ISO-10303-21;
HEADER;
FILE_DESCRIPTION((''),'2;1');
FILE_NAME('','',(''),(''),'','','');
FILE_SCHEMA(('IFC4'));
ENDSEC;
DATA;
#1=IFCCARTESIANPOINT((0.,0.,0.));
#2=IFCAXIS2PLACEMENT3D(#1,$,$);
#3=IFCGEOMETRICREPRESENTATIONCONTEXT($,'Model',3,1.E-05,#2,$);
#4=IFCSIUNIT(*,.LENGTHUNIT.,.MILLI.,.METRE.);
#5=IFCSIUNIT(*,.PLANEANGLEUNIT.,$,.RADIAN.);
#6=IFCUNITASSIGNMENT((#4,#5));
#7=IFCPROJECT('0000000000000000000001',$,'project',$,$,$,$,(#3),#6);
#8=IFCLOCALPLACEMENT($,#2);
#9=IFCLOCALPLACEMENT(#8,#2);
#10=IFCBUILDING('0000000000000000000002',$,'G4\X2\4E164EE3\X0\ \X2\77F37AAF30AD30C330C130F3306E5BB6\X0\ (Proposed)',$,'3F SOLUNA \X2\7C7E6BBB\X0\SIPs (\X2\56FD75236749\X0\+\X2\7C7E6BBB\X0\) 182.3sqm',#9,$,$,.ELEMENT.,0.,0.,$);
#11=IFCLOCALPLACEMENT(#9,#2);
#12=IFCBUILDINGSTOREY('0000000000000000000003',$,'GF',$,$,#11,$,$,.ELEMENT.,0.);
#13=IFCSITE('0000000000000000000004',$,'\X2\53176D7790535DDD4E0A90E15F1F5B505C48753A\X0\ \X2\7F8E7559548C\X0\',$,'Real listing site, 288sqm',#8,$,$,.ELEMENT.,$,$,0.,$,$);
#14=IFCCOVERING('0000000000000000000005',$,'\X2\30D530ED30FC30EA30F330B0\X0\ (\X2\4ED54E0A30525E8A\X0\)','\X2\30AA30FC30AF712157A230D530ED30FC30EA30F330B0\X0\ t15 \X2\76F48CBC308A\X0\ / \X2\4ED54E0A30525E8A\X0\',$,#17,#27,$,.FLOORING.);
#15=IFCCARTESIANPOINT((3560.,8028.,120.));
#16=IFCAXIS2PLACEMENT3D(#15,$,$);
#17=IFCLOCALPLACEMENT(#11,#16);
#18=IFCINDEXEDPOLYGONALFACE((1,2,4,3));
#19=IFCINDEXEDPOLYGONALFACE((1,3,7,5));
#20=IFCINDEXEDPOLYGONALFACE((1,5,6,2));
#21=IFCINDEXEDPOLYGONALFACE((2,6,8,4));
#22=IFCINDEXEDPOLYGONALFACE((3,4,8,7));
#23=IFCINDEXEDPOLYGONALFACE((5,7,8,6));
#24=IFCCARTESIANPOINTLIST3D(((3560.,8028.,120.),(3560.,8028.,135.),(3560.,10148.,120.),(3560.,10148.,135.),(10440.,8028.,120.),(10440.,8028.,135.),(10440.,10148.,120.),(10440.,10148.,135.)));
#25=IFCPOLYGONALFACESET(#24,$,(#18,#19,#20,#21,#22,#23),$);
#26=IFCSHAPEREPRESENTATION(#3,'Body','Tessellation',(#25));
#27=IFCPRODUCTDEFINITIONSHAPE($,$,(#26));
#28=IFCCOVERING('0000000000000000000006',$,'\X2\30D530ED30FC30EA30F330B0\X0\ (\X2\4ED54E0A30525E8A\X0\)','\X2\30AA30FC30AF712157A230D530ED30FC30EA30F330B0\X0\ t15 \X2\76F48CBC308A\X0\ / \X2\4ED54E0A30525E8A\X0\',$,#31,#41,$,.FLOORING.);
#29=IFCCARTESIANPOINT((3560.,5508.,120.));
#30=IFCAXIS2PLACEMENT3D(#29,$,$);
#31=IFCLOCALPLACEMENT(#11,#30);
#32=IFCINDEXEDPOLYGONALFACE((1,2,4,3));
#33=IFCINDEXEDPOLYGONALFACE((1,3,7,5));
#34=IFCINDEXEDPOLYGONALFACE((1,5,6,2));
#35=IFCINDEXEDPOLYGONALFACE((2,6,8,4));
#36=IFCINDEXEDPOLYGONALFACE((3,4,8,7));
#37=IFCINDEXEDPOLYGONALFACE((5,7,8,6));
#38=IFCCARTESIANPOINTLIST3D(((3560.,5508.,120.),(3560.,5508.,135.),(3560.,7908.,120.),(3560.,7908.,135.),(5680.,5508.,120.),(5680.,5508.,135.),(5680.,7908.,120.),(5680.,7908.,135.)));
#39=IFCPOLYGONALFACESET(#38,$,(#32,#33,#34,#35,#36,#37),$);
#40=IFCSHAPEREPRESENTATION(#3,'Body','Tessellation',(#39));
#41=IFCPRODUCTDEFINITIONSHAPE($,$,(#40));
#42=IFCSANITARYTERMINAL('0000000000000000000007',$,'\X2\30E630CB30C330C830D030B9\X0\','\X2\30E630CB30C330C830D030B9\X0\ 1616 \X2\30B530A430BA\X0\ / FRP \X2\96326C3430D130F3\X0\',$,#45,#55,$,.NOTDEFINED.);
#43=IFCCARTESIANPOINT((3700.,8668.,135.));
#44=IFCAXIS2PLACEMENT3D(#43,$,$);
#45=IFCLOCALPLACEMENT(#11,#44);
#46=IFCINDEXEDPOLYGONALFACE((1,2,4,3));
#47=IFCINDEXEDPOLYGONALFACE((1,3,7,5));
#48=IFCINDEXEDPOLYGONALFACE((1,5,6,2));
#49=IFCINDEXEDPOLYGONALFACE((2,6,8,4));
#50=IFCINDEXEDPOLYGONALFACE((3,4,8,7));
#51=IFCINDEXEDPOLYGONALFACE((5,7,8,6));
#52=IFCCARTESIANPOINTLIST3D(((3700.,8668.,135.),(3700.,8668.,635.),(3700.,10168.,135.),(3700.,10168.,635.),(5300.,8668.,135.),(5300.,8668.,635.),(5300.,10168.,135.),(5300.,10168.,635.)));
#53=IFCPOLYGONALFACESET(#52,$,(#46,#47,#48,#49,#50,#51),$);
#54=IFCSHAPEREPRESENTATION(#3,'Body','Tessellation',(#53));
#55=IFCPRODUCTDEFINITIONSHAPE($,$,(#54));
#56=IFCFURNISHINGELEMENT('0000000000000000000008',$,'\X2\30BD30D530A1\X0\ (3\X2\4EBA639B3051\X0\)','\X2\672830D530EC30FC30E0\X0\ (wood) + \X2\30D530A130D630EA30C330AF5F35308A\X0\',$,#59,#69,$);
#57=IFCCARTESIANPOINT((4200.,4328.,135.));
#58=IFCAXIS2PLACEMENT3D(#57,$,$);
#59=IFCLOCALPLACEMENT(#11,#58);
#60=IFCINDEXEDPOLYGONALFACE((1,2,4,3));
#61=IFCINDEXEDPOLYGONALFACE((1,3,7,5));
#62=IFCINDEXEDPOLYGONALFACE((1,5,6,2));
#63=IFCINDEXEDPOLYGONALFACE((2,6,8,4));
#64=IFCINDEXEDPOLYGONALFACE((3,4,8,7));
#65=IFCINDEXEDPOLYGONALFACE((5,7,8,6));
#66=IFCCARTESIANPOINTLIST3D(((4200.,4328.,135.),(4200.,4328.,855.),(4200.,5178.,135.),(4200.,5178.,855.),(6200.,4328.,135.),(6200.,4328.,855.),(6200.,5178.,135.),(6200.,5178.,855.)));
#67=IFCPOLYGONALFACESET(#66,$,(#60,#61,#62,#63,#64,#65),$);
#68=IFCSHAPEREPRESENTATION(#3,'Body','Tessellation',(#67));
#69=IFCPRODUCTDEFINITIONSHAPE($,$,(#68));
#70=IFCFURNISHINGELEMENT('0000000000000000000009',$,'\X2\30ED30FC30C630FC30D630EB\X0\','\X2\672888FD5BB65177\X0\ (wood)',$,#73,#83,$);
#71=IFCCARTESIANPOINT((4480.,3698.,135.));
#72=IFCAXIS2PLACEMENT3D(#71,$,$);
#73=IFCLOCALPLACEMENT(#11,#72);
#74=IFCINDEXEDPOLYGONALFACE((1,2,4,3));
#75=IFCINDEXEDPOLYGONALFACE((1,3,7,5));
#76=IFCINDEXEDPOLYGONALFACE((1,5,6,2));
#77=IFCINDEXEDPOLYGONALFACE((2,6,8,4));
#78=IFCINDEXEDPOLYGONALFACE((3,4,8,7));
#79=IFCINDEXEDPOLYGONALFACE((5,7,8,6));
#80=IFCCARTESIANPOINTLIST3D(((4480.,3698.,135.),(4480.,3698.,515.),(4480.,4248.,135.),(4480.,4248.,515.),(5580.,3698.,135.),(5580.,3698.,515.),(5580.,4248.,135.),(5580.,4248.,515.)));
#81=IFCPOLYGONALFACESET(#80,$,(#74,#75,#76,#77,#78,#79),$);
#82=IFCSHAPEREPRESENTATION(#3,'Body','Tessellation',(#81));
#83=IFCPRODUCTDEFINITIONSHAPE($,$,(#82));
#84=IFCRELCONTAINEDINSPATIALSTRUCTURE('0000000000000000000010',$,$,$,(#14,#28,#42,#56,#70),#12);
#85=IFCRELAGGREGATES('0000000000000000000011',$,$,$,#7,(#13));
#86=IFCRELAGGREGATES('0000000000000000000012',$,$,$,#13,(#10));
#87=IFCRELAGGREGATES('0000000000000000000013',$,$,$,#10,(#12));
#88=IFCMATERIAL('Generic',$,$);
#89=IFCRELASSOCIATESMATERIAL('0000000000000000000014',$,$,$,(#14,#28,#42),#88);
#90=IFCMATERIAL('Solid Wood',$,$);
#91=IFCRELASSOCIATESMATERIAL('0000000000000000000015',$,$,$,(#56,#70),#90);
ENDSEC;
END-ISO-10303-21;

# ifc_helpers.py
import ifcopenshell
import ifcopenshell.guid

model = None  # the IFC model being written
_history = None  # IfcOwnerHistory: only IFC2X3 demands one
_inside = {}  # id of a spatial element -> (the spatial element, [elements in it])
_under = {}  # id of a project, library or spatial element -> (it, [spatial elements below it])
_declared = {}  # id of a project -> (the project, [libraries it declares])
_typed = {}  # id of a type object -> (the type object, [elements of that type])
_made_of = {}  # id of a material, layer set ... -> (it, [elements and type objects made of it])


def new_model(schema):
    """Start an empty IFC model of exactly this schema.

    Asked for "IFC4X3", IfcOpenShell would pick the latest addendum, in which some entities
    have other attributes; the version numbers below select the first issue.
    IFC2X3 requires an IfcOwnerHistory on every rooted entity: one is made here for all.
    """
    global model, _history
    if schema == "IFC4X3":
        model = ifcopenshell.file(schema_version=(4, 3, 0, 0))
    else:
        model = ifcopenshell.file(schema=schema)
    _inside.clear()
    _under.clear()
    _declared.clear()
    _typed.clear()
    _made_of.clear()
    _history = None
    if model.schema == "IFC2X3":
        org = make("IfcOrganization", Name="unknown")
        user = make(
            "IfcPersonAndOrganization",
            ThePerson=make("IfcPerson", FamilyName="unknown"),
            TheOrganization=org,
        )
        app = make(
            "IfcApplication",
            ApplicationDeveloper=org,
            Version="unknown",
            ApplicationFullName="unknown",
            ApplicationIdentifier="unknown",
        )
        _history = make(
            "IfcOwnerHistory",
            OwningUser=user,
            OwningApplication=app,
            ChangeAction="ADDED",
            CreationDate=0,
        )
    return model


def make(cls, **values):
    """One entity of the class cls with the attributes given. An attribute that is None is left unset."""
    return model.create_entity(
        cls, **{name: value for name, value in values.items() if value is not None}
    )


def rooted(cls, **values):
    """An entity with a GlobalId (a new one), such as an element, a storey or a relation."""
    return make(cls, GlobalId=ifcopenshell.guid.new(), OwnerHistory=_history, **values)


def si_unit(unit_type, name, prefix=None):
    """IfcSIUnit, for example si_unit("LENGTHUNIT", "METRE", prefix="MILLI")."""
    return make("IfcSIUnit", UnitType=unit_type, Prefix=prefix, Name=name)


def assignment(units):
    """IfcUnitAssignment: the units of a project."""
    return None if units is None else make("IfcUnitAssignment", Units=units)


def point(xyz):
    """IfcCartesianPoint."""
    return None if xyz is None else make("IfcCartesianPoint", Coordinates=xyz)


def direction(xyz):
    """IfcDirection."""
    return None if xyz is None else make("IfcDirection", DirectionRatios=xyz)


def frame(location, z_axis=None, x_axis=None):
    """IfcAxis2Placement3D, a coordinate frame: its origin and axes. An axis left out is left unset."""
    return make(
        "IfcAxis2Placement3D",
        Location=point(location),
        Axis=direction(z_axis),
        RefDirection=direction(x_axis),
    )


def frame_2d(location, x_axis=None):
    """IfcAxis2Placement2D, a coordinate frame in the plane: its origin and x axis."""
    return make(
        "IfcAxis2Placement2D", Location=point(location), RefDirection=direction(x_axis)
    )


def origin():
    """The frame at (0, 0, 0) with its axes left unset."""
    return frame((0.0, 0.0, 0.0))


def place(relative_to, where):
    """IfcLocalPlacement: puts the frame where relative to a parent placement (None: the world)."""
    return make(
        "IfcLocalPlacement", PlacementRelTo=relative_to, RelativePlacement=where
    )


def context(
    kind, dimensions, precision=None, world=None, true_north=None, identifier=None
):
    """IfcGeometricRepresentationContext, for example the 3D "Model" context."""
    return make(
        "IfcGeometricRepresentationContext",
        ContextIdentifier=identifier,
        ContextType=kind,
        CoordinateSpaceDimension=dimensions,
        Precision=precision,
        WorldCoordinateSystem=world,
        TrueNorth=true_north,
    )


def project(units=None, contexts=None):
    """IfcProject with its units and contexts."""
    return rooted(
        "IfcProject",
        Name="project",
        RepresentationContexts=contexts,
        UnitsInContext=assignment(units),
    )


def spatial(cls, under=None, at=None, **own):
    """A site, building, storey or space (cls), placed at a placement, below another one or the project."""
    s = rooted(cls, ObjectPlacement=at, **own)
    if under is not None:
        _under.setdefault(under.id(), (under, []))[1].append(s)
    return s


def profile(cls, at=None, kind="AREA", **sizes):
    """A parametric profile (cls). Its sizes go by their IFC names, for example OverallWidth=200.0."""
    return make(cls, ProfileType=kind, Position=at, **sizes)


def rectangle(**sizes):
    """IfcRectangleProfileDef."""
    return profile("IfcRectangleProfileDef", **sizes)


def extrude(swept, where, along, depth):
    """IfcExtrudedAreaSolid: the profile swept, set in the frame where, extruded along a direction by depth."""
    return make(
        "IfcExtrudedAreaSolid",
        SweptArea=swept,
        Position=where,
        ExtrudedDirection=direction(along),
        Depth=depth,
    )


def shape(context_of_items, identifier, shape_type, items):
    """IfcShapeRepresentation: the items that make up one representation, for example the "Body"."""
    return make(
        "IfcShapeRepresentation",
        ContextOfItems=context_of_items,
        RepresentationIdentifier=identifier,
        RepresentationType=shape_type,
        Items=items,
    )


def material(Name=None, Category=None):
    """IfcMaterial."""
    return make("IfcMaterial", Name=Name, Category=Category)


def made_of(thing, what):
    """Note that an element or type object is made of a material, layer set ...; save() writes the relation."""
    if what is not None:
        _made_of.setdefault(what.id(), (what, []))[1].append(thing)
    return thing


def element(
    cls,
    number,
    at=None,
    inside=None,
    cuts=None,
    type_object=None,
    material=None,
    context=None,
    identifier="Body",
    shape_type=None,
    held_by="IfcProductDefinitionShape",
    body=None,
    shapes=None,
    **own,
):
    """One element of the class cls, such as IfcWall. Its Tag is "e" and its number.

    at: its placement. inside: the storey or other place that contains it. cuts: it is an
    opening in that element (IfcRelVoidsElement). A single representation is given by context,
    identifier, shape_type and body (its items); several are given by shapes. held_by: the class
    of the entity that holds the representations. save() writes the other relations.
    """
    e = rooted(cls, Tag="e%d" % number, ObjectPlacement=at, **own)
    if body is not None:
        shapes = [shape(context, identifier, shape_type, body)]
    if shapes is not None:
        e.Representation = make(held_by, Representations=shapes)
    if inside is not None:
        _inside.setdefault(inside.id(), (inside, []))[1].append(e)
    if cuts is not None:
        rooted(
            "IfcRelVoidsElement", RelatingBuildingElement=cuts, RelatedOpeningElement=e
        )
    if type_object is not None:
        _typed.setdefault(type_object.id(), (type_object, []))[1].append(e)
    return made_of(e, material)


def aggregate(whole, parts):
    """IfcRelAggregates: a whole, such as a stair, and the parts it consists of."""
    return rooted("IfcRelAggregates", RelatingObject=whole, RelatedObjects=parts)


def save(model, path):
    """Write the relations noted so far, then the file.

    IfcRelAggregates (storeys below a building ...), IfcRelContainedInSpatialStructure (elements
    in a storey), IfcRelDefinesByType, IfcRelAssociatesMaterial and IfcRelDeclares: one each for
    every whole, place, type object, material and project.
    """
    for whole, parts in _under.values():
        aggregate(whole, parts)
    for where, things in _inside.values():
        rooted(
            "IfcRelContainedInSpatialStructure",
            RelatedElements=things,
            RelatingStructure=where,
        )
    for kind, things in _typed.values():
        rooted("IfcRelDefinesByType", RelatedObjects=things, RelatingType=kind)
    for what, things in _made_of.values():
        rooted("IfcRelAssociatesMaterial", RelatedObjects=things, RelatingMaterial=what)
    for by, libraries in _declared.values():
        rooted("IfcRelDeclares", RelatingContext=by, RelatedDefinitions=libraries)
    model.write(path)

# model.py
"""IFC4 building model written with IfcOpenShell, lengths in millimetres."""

from ifc_helpers import new_model, si_unit, frame, frame_2d, origin, place, context, project, spatial, rectangle, extrude, material, element, save


model = new_model("IFC4")

# Units and contexts
model_context = context("Model", 3, precision=1e-05, world=origin())
ifc_project = project(units=[si_unit("LENGTHUNIT", "METRE", prefix="MILLI"), si_unit("PLANEANGLEUNIT", "RADIAN")], contexts=[model_context])

# Site, building, storey
site_placement = place(None, origin())
site = spatial("IfcSite", under=ifc_project, at=site_placement, Name="北海道川上郡弟子屈町 美留和", ObjectType="Real listing site, 288sqm", CompositionType="ELEMENT", RefElevation=0.0)
building_placement = place(site_placement, origin())
building = spatial("IfcBuilding", under=site, at=building_placement, Name="G4世代 石窯キッチンの家 (Proposed)", ObjectType="3F SOLUNA 籾殻SIPs (国産杉+籾殻) 182.3sqm", CompositionType="ELEMENT", ElevationOfRefHeight=0.0, ElevationOfTerrain=0.0)
storey_placement = place(building_placement, origin())
storey = spatial("IfcBuildingStorey", under=building, at=storey_placement, Name="GF", CompositionType="ELEMENT", Elevation=0.0)

# Shared definitions
ifc_material_1 = material(Name="Solid Wood")

# Coverings
ifc_material_2 = material(Name="Generic")
covering_1_placement = place(storey_placement, frame((3560.0, 8028.0, 120.0)))
element("IfcCovering", 1, at=covering_1_placement, inside=storey, material=ifc_material_2, Name="フローリング (仕上げ床)", Description="オーク無垢フローリング t15 直貼り / 仕上げ床", PredefinedType="FLOORING", context=model_context, shape_type="SweptSolid", body=[
    extrude(rectangle(XDim=6880.0, YDim=2120.0, at=frame_2d((3440.0, 1060.0))), frame((3560.0, 8028.0, 120.0)), (0.0, 0.0, 1.0), 15.0),
])
covering_2_placement = place(storey_placement, frame((3560.0, 5508.0, 120.0)))
element("IfcCovering", 2, at=covering_2_placement, inside=storey, material=ifc_material_2, Name="フローリング (仕上げ床)", Description="オーク無垢フローリング t15 直貼り / 仕上げ床", PredefinedType="FLOORING", context=model_context, shape_type="SweptSolid", body=[
    extrude(rectangle(XDim=2120.0, YDim=2400.0, at=frame_2d((1060.0, 1200.0))), frame((3560.0, 5508.0, 120.0)), (0.0, 0.0, 1.0), 15.0),
])

# Sanitary terminal
sanitary_terminal_placement = place(storey_placement, frame((3700.0, 8668.0, 135.0)))
element("IfcSanitaryTerminal", 3, at=sanitary_terminal_placement, inside=storey, material=ifc_material_2, Name="ユニットバス", Description="ユニットバス 1616 サイズ / FRP 防水パン", PredefinedType="NOTDEFINED", context=model_context, shape_type="SweptSolid", body=[
    extrude(rectangle(XDim=1600.0, YDim=1500.0, at=frame_2d((800.0, 750.0))), frame((3700.0, 8668.0, 135.0)), (0.0, 0.0, 1.0), 500.0),
])

# Furnishing elements
furnishing_1_placement = place(storey_placement, frame((4200.0, 4328.0, 135.0)))
element("IfcFurnishingElement", 4, at=furnishing_1_placement, inside=storey, material=ifc_material_1, Name="ソファ (3人掛け)", Description="木フレーム (wood) + ファブリック張り", context=model_context, shape_type="SweptSolid", body=[
    extrude(rectangle(XDim=2000.0, YDim=850.0, at=frame_2d((1000.0, 425.0))), frame((4200.0, 4328.0, 135.0)), (0.0, 0.0, 1.0), 720.0),
])
furnishing_2_placement = place(storey_placement, frame((4480.0, 3698.0, 135.0)))
element("IfcFurnishingElement", 5, at=furnishing_2_placement, inside=storey, material=ifc_material_1, Name="ローテーブル", Description="木製家具 (wood)", context=model_context, shape_type="SweptSolid", body=[
    extrude(rectangle(XDim=1100.0, YDim=550.0, at=frame_2d((550.0, 275.0))), frame((4480.0, 3698.0, 135.0)), (0.0, 0.0, 1.0), 380.0),
])

save(model, "model.ifc")
